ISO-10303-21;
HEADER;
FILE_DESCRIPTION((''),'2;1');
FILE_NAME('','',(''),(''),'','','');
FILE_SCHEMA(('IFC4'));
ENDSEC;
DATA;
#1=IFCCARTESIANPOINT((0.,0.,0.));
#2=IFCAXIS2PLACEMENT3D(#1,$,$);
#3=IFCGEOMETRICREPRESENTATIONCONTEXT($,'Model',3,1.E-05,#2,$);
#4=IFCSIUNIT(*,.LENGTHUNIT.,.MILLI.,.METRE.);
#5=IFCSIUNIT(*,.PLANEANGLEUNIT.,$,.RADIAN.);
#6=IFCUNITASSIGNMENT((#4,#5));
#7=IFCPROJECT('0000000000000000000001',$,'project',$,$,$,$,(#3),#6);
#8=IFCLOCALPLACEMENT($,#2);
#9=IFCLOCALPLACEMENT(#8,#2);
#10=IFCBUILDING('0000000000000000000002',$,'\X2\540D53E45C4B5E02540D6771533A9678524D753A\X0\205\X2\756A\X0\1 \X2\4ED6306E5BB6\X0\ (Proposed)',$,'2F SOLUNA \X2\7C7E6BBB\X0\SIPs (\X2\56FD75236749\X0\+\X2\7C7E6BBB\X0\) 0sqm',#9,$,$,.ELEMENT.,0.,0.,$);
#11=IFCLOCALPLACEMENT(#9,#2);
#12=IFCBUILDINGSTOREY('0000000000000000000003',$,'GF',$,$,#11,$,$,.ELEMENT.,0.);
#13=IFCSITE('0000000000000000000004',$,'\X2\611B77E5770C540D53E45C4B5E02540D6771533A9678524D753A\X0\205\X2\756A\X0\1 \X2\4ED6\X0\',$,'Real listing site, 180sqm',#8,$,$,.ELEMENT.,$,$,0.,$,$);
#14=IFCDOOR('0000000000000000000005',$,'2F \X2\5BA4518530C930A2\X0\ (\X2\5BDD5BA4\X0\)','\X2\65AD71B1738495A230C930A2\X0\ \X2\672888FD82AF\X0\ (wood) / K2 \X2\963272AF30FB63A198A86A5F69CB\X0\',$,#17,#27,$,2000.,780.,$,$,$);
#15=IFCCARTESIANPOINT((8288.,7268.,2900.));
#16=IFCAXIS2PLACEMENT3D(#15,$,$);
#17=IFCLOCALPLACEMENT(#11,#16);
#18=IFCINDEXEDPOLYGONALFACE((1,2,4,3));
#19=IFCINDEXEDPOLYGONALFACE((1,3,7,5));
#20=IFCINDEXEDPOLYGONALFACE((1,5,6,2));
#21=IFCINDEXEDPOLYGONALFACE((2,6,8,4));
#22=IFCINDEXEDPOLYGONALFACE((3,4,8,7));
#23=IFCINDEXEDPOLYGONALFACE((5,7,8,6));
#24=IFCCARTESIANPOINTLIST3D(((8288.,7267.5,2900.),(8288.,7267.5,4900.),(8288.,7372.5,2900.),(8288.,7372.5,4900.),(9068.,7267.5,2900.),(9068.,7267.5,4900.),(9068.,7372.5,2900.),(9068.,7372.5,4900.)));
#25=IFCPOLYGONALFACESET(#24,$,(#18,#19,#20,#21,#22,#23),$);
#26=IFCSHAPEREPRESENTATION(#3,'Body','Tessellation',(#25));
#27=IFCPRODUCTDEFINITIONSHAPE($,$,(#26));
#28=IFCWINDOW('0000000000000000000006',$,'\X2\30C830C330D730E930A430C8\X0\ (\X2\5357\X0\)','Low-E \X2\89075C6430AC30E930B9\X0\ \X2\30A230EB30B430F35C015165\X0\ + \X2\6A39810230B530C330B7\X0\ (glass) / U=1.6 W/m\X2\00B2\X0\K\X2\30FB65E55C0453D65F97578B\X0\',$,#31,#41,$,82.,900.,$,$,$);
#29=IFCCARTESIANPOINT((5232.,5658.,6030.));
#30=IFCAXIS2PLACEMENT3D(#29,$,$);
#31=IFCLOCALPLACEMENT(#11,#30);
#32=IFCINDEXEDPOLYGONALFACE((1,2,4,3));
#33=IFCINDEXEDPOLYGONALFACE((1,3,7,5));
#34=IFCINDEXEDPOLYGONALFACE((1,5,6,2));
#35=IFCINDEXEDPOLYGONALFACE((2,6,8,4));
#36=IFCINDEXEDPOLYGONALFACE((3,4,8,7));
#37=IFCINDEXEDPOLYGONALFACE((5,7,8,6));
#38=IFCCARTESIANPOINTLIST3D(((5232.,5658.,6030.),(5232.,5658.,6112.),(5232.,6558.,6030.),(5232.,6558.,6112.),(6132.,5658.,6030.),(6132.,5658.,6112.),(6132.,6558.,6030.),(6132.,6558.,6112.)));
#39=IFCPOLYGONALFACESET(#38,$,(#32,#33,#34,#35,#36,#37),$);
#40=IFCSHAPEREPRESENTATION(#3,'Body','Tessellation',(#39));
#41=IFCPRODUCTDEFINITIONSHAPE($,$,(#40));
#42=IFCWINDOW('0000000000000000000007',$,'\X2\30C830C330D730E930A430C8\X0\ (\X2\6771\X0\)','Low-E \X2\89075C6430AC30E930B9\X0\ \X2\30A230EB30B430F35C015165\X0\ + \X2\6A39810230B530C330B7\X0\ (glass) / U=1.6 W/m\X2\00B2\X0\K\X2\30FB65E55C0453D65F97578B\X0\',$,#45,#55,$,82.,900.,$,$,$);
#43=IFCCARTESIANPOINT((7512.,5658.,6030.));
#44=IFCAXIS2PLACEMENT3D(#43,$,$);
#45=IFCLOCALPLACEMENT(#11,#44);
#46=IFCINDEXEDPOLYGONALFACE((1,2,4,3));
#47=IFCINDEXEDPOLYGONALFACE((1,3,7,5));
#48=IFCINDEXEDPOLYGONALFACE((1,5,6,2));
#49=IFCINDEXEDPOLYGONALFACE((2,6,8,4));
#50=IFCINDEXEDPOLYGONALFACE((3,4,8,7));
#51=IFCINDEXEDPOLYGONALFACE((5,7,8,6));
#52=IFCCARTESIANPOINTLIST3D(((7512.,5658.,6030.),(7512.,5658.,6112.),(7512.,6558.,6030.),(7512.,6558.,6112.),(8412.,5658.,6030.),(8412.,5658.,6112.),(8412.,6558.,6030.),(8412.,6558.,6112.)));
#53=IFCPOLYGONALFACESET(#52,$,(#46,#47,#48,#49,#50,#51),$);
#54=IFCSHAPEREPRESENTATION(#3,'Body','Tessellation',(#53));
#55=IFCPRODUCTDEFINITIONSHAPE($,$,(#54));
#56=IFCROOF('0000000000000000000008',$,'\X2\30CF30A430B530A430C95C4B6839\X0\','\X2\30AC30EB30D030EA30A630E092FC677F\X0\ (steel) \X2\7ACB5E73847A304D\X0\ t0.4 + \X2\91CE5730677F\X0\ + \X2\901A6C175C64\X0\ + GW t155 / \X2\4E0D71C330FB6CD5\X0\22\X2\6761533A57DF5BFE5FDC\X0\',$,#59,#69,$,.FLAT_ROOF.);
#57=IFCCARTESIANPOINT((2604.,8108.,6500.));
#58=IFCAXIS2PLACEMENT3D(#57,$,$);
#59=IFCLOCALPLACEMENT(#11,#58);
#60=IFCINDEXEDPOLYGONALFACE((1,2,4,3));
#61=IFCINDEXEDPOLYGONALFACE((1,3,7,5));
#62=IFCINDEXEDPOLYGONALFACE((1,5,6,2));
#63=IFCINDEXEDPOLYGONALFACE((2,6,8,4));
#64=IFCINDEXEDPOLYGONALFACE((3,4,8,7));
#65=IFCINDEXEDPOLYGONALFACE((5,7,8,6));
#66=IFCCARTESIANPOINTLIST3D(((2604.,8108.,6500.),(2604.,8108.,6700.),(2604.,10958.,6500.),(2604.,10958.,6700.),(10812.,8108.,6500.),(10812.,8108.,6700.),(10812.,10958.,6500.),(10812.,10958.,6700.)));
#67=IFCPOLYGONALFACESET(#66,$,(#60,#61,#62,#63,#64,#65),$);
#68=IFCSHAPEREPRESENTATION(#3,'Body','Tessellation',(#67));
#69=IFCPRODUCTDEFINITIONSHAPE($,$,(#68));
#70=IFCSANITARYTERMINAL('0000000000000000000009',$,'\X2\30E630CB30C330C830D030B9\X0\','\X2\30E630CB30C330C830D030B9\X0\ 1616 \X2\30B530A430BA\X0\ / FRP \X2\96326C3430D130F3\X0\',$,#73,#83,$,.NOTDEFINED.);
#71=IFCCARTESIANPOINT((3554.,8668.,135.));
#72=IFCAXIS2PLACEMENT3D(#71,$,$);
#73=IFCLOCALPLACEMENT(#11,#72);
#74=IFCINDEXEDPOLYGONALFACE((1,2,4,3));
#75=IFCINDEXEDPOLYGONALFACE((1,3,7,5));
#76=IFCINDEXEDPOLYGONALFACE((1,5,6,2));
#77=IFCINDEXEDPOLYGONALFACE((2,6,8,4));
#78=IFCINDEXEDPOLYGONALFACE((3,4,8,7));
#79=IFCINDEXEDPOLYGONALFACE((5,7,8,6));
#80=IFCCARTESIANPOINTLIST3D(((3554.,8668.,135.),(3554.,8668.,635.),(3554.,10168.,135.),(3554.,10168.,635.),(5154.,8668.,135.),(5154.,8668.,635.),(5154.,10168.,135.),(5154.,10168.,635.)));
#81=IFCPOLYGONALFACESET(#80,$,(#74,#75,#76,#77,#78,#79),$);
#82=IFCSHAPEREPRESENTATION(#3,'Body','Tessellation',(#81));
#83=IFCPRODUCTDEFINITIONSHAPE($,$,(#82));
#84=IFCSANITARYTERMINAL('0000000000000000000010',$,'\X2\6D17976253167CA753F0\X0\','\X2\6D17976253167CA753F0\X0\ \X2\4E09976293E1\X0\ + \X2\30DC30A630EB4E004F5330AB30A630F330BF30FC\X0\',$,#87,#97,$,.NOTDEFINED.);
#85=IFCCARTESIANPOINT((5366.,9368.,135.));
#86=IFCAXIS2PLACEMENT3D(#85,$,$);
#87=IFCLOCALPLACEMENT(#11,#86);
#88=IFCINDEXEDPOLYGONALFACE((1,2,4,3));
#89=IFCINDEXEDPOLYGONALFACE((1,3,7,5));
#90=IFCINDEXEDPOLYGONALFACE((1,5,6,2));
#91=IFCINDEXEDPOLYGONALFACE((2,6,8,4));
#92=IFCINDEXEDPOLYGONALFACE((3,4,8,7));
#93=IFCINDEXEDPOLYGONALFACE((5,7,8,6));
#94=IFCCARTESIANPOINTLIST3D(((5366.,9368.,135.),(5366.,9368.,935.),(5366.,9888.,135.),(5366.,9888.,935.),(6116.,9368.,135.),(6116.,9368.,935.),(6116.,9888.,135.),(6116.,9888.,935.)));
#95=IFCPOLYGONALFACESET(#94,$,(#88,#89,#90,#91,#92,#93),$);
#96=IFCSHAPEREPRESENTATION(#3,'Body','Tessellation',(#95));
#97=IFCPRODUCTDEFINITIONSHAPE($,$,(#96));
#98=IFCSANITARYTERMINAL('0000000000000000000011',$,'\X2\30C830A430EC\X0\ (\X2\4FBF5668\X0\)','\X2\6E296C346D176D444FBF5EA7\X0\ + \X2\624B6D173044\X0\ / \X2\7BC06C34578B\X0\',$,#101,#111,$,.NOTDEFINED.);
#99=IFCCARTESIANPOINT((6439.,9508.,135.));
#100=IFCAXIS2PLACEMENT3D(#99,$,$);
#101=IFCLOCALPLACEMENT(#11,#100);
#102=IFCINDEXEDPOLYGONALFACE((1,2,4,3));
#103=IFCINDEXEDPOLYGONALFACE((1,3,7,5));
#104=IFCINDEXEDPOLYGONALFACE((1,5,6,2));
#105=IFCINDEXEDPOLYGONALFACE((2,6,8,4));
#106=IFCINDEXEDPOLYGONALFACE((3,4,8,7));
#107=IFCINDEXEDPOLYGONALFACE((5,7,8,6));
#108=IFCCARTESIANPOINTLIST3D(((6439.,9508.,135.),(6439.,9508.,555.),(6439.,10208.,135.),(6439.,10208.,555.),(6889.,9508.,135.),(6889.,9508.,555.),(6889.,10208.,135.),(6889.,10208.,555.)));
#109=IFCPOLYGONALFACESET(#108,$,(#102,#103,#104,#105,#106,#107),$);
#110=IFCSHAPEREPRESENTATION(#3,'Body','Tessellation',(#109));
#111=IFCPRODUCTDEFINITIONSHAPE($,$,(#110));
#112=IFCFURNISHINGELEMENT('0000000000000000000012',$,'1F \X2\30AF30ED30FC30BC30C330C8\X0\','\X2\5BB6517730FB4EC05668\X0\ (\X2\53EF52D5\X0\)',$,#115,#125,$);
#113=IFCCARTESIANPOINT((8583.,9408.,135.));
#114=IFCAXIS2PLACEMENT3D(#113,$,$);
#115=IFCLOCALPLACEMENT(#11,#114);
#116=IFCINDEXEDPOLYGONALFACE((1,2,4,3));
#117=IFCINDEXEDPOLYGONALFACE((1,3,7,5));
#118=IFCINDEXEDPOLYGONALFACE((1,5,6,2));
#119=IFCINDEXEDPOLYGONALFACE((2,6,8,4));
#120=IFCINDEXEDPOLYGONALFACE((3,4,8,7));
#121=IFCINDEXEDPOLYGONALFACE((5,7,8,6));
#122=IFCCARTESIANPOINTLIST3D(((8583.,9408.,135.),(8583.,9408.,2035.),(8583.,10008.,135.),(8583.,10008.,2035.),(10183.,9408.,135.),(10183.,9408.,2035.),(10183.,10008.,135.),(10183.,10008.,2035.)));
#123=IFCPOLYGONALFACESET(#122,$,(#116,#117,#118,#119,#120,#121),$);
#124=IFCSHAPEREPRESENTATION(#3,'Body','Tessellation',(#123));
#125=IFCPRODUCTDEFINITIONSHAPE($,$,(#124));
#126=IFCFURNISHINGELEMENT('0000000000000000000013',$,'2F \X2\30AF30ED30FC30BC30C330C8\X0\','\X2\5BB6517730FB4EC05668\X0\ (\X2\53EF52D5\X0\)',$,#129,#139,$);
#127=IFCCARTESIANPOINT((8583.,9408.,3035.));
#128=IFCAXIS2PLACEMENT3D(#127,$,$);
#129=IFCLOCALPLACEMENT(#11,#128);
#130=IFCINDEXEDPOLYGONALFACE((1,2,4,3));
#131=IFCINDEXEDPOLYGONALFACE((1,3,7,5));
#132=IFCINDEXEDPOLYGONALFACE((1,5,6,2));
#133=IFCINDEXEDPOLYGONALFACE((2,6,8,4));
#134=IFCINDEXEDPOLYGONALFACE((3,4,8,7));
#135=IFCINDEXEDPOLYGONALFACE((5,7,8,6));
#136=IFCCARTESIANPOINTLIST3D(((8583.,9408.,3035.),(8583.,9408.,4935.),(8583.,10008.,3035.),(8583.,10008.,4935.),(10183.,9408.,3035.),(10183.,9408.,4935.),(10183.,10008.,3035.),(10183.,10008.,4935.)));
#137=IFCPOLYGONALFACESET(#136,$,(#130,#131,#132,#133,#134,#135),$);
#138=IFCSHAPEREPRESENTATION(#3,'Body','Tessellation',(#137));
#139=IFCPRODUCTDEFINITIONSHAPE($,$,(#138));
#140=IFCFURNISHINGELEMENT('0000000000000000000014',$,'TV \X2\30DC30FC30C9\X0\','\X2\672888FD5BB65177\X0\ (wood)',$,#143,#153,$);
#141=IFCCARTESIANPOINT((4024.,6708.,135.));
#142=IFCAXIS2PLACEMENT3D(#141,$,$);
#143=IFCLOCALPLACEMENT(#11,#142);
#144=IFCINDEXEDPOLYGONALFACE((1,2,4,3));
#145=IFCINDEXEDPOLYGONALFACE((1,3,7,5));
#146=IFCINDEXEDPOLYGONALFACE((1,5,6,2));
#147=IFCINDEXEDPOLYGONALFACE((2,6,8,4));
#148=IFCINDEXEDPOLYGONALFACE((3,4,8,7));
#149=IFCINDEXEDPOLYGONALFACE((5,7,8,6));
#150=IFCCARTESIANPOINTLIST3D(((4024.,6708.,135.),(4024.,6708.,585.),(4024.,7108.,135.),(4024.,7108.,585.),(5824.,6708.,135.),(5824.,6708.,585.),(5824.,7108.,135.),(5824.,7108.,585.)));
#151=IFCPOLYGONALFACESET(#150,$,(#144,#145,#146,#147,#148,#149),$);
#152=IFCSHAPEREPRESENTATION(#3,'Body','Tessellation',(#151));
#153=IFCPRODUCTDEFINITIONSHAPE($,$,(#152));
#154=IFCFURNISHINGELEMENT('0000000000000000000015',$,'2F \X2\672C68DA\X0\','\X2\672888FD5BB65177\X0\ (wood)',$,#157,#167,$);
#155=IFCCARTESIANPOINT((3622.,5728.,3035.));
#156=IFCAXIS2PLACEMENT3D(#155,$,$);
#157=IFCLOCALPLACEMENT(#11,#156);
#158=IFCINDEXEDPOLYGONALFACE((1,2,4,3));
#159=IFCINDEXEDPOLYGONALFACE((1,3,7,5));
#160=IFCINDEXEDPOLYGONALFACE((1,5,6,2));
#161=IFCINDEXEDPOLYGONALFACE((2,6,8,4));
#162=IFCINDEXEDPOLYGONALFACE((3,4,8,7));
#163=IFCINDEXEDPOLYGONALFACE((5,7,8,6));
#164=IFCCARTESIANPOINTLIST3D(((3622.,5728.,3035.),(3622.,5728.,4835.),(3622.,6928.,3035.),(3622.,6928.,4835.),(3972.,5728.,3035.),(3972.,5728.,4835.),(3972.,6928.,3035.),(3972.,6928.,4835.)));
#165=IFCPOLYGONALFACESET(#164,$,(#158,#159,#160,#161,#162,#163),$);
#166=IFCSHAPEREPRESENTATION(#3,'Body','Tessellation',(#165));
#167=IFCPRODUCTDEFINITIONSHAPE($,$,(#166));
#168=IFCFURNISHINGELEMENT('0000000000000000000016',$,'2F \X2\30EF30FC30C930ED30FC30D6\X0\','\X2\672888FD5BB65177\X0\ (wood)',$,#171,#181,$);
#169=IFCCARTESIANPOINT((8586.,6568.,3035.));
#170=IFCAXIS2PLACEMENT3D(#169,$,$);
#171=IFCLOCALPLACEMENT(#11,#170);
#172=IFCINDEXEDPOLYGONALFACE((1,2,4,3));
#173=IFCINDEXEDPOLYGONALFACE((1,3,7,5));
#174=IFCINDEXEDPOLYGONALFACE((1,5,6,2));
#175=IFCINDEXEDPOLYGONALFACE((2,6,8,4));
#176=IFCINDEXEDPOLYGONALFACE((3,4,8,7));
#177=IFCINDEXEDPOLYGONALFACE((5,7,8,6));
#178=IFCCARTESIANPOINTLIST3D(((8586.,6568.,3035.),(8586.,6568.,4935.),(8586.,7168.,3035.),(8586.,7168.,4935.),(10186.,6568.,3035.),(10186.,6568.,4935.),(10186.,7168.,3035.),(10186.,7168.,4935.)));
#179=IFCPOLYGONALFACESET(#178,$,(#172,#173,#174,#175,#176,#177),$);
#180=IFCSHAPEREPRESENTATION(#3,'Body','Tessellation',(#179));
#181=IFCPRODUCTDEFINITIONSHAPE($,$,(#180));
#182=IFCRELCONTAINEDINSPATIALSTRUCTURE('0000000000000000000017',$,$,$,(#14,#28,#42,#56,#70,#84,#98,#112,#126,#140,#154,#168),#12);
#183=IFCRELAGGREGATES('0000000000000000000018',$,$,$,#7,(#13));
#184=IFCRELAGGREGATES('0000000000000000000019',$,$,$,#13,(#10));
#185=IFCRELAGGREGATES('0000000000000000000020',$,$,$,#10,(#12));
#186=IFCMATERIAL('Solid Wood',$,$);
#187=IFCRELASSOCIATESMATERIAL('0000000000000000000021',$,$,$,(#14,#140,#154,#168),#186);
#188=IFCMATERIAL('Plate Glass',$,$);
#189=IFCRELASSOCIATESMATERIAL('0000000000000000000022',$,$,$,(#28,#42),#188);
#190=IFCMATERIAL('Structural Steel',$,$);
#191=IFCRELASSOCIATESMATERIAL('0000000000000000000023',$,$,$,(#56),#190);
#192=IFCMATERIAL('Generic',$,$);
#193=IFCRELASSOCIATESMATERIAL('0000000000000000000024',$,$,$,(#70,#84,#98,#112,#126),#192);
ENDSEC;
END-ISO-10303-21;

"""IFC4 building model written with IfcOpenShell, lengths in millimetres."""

from ifc_helpers import new_model, si_unit, frame, frame_2d, origin, place, context, project, spatial, rectangle, extrude, material, element, save


model = new_model("IFC4")

# Units and contexts
model_context = context("Model", 3, precision=1e-05, world=origin())
ifc_project = project(units=[si_unit("LENGTHUNIT", "METRE", prefix="MILLI"), si_unit("PLANEANGLEUNIT", "RADIAN")], contexts=[model_context])

# Site, building, storey
site_placement = place(None, origin())
site = spatial("IfcSite", under=ifc_project, at=site_placement, Name="愛知県名古屋市名東区陸前町205番1 他", ObjectType="Real listing site, 180sqm", CompositionType="ELEMENT", RefElevation=0.0)
building_placement = place(site_placement, origin())
building = spatial("IfcBuilding", under=site, at=building_placement, Name="名古屋市名東区陸前町205番1 他の家 (Proposed)", ObjectType="2F SOLUNA 籾殻SIPs (国産杉+籾殻) 0sqm", CompositionType="ELEMENT", ElevationOfRefHeight=0.0, ElevationOfTerrain=0.0)
storey_placement = place(building_placement, origin())
storey = spatial("IfcBuildingStorey", under=building, at=storey_placement, Name="GF", CompositionType="ELEMENT", Elevation=0.0)

# Shared definitions
ifc_material_1 = material(Name="Solid Wood")
ifc_material_2 = material(Name="Plate Glass")

# Door
door_1_placement = place(storey_placement, frame((8288.0, 7268.0, 2900.0)))
element("IfcDoor", 1, at=door_1_placement, inside=storey, material=ifc_material_1, Name="2F 室内ドア (寝室)", Description="断熱玄関ドア 木製芯 (wood) / K2 防犯・採風機構", OverallHeight=2000.0, OverallWidth=780.0, context=model_context, shape_type="SweptSolid", body=[
    extrude(rectangle(XDim=780.0, YDim=105.0, at=frame_2d((390.0, 52.0))), frame((8288.0, 7268.0, 2900.0)), (0.0, 0.0, 1.0), 2000.0),
])

# Windows
window_1_placement = place(storey_placement, frame((5232.0, 5658.0, 6030.0)))
element("IfcWindow", 2, at=window_1_placement, inside=storey, material=ifc_material_2, Name="トップライト (南)", Description="Low-E 複層ガラス アルゴン封入 + 樹脂サッシ (glass) / U=1.6 W/m²K・日射取得型", OverallHeight=82.0, OverallWidth=900.0, context=model_context, shape_type="SweptSolid", body=[
    extrude(rectangle(XDim=900.0, YDim=900.0, at=frame_2d((450.0, 450.0))), frame((5232.0, 5658.0, 6030.0)), (0.0, 0.0, 1.0), 82.0),
])
window_2_placement = place(storey_placement, frame((7512.0, 5658.0, 6030.0)))
element("IfcWindow", 3, at=window_2_placement, inside=storey, material=ifc_material_2, Name="トップライト (東)", Description="Low-E 複層ガラス アルゴン封入 + 樹脂サッシ (glass) / U=1.6 W/m²K・日射取得型", OverallHeight=82.0, OverallWidth=900.0, context=model_context, shape_type="SweptSolid", body=[
    extrude(rectangle(XDim=900.0, YDim=900.0, at=frame_2d((450.0, 450.0))), frame((7512.0, 5658.0, 6030.0)), (0.0, 0.0, 1.0), 82.0),
])

# Roof
ifc_material_3 = material(Name="Structural Steel")
roof_placement = place(storey_placement, frame((2604.0, 8108.0, 6500.0)))
element("IfcRoof", 4, at=roof_placement, inside=storey, material=ifc_material_3, Name="ハイサイド屋根", Description="ガルバリウム鋼板 (steel) 立平葺き t0.4 + 野地板 + 通気層 + GW t155 / 不燃・法22条区域対応", PredefinedType="FLAT_ROOF", context=model_context, shape_type="SweptSolid", body=[
    extrude(rectangle(XDim=8208.0, YDim=2850.0, at=frame_2d((4104.0, 1425.0))), frame((2604.0, 8108.0, 6500.0)), (0.0, 0.0, 1.0), 200.0),
])

# Sanitary terminals
ifc_material_4 = material(Name="Generic")
sanitary_terminal_1_placement = place(storey_placement, frame((3554.0, 8668.0, 135.0)))
element("IfcSanitaryTerminal", 5, at=sanitary_terminal_1_placement, inside=storey, material=ifc_material_4, Name="ユニットバス", Description="ユニットバス 1616 サイズ / FRP 防水パン", PredefinedType="NOTDEFINED", context=model_context, shape_type="SweptSolid", body=[
    extrude(rectangle(XDim=1600.0, YDim=1500.0, at=frame_2d((800.0, 750.0))), frame((3554.0, 8668.0, 135.0)), (0.0, 0.0, 1.0), 500.0),
])
sanitary_terminal_2_placement = place(storey_placement, frame((5366.0, 9368.0, 135.0)))
element("IfcSanitaryTerminal", 6, at=sanitary_terminal_2_placement, inside=storey, material=ifc_material_4, Name="洗面化粧台", Description="洗面化粧台 三面鏡 + ボウル一体カウンター", PredefinedType="NOTDEFINED", context=model_context, shape_type="SweptSolid", body=[
    extrude(rectangle(XDim=750.0, YDim=520.0, at=frame_2d((375.0, 260.0))), frame((5366.0, 9368.0, 135.0)), (0.0, 0.0, 1.0), 800.0),
])
sanitary_terminal_3_placement = place(storey_placement, frame((6439.0, 9508.0, 135.0)))
element("IfcSanitaryTerminal", 7, at=sanitary_terminal_3_placement, inside=storey, material=ifc_material_4, Name="トイレ (便器)", Description="温水洗浄便座 + 手洗い / 節水型", PredefinedType="NOTDEFINED", context=model_context, shape_type="SweptSolid", body=[
    extrude(rectangle(XDim=450.0, YDim=700.0, at=frame_2d((225.0, 350.0))), frame((6439.0, 9508.0, 135.0)), (0.0, 0.0, 1.0), 420.0),
])

# Furnishing elements
furnishing_1_placement = place(storey_placement, frame((8583.0, 9408.0, 135.0)))
element("IfcFurnishingElement", 8, at=furnishing_1_placement, inside=storey, material=ifc_material_4, Name="1F クローゼット", Description="家具・什器 (可動)", context=model_context, shape_type="SweptSolid", body=[
    extrude(rectangle(XDim=1600.0, YDim=600.0, at=frame_2d((800.0, 300.0))), frame((8583.0, 9408.0, 135.0)), (0.0, 0.0, 1.0), 1900.0),
])
furnishing_2_placement = place(storey_placement, frame((8583.0, 9408.0, 3035.0)))
element("IfcFurnishingElement", 9, at=furnishing_2_placement, inside=storey, material=ifc_material_4, Name="2F クローゼット", Description="家具・什器 (可動)", context=model_context, shape_type="SweptSolid", body=[
    extrude(rectangle(XDim=1600.0, YDim=600.0, at=frame_2d((800.0, 300.0))), frame((8583.0, 9408.0, 3035.0)), (0.0, 0.0, 1.0), 1900.0),
])
furnishing_3_placement = place(storey_placement, frame((4024.0, 6708.0, 135.0)))
element("IfcFurnishingElement", 10, at=furnishing_3_placement, inside=storey, material=ifc_material_1, Name="TV ボード", Description="木製家具 (wood)", context=model_context, shape_type="SweptSolid", body=[
    extrude(rectangle(XDim=1800.0, YDim=400.0, at=frame_2d((900.0, 200.0))), frame((4024.0, 6708.0, 135.0)), (0.0, 0.0, 1.0), 450.0),
])
furnishing_4_placement = place(storey_placement, frame((3622.0, 5728.0, 3035.0)))
element("IfcFurnishingElement", 11, at=furnishing_4_placement, inside=storey, material=ifc_material_1, Name="2F 本棚", Description="木製家具 (wood)", context=model_context, shape_type="SweptSolid", body=[
    extrude(rectangle(XDim=350.0, YDim=1200.0, at=frame_2d((175.0, 600.0))), frame((3622.0, 5728.0, 3035.0)), (0.0, 0.0, 1.0), 1800.0),
])
furnishing_5_placement = place(storey_placement, frame((8586.0, 6568.0, 3035.0)))
element("IfcFurnishingElement", 12, at=furnishing_5_placement, inside=storey, material=ifc_material_1, Name="2F ワードローブ", Description="木製家具 (wood)", context=model_context, shape_type="SweptSolid", body=[
    extrude(rectangle(XDim=1600.0, YDim=600.0, at=frame_2d((800.0, 300.0))), frame((8586.0, 6568.0, 3035.0)), (0.0, 0.0, 1.0), 1900.0),
])

save(model, "model.ifc")
